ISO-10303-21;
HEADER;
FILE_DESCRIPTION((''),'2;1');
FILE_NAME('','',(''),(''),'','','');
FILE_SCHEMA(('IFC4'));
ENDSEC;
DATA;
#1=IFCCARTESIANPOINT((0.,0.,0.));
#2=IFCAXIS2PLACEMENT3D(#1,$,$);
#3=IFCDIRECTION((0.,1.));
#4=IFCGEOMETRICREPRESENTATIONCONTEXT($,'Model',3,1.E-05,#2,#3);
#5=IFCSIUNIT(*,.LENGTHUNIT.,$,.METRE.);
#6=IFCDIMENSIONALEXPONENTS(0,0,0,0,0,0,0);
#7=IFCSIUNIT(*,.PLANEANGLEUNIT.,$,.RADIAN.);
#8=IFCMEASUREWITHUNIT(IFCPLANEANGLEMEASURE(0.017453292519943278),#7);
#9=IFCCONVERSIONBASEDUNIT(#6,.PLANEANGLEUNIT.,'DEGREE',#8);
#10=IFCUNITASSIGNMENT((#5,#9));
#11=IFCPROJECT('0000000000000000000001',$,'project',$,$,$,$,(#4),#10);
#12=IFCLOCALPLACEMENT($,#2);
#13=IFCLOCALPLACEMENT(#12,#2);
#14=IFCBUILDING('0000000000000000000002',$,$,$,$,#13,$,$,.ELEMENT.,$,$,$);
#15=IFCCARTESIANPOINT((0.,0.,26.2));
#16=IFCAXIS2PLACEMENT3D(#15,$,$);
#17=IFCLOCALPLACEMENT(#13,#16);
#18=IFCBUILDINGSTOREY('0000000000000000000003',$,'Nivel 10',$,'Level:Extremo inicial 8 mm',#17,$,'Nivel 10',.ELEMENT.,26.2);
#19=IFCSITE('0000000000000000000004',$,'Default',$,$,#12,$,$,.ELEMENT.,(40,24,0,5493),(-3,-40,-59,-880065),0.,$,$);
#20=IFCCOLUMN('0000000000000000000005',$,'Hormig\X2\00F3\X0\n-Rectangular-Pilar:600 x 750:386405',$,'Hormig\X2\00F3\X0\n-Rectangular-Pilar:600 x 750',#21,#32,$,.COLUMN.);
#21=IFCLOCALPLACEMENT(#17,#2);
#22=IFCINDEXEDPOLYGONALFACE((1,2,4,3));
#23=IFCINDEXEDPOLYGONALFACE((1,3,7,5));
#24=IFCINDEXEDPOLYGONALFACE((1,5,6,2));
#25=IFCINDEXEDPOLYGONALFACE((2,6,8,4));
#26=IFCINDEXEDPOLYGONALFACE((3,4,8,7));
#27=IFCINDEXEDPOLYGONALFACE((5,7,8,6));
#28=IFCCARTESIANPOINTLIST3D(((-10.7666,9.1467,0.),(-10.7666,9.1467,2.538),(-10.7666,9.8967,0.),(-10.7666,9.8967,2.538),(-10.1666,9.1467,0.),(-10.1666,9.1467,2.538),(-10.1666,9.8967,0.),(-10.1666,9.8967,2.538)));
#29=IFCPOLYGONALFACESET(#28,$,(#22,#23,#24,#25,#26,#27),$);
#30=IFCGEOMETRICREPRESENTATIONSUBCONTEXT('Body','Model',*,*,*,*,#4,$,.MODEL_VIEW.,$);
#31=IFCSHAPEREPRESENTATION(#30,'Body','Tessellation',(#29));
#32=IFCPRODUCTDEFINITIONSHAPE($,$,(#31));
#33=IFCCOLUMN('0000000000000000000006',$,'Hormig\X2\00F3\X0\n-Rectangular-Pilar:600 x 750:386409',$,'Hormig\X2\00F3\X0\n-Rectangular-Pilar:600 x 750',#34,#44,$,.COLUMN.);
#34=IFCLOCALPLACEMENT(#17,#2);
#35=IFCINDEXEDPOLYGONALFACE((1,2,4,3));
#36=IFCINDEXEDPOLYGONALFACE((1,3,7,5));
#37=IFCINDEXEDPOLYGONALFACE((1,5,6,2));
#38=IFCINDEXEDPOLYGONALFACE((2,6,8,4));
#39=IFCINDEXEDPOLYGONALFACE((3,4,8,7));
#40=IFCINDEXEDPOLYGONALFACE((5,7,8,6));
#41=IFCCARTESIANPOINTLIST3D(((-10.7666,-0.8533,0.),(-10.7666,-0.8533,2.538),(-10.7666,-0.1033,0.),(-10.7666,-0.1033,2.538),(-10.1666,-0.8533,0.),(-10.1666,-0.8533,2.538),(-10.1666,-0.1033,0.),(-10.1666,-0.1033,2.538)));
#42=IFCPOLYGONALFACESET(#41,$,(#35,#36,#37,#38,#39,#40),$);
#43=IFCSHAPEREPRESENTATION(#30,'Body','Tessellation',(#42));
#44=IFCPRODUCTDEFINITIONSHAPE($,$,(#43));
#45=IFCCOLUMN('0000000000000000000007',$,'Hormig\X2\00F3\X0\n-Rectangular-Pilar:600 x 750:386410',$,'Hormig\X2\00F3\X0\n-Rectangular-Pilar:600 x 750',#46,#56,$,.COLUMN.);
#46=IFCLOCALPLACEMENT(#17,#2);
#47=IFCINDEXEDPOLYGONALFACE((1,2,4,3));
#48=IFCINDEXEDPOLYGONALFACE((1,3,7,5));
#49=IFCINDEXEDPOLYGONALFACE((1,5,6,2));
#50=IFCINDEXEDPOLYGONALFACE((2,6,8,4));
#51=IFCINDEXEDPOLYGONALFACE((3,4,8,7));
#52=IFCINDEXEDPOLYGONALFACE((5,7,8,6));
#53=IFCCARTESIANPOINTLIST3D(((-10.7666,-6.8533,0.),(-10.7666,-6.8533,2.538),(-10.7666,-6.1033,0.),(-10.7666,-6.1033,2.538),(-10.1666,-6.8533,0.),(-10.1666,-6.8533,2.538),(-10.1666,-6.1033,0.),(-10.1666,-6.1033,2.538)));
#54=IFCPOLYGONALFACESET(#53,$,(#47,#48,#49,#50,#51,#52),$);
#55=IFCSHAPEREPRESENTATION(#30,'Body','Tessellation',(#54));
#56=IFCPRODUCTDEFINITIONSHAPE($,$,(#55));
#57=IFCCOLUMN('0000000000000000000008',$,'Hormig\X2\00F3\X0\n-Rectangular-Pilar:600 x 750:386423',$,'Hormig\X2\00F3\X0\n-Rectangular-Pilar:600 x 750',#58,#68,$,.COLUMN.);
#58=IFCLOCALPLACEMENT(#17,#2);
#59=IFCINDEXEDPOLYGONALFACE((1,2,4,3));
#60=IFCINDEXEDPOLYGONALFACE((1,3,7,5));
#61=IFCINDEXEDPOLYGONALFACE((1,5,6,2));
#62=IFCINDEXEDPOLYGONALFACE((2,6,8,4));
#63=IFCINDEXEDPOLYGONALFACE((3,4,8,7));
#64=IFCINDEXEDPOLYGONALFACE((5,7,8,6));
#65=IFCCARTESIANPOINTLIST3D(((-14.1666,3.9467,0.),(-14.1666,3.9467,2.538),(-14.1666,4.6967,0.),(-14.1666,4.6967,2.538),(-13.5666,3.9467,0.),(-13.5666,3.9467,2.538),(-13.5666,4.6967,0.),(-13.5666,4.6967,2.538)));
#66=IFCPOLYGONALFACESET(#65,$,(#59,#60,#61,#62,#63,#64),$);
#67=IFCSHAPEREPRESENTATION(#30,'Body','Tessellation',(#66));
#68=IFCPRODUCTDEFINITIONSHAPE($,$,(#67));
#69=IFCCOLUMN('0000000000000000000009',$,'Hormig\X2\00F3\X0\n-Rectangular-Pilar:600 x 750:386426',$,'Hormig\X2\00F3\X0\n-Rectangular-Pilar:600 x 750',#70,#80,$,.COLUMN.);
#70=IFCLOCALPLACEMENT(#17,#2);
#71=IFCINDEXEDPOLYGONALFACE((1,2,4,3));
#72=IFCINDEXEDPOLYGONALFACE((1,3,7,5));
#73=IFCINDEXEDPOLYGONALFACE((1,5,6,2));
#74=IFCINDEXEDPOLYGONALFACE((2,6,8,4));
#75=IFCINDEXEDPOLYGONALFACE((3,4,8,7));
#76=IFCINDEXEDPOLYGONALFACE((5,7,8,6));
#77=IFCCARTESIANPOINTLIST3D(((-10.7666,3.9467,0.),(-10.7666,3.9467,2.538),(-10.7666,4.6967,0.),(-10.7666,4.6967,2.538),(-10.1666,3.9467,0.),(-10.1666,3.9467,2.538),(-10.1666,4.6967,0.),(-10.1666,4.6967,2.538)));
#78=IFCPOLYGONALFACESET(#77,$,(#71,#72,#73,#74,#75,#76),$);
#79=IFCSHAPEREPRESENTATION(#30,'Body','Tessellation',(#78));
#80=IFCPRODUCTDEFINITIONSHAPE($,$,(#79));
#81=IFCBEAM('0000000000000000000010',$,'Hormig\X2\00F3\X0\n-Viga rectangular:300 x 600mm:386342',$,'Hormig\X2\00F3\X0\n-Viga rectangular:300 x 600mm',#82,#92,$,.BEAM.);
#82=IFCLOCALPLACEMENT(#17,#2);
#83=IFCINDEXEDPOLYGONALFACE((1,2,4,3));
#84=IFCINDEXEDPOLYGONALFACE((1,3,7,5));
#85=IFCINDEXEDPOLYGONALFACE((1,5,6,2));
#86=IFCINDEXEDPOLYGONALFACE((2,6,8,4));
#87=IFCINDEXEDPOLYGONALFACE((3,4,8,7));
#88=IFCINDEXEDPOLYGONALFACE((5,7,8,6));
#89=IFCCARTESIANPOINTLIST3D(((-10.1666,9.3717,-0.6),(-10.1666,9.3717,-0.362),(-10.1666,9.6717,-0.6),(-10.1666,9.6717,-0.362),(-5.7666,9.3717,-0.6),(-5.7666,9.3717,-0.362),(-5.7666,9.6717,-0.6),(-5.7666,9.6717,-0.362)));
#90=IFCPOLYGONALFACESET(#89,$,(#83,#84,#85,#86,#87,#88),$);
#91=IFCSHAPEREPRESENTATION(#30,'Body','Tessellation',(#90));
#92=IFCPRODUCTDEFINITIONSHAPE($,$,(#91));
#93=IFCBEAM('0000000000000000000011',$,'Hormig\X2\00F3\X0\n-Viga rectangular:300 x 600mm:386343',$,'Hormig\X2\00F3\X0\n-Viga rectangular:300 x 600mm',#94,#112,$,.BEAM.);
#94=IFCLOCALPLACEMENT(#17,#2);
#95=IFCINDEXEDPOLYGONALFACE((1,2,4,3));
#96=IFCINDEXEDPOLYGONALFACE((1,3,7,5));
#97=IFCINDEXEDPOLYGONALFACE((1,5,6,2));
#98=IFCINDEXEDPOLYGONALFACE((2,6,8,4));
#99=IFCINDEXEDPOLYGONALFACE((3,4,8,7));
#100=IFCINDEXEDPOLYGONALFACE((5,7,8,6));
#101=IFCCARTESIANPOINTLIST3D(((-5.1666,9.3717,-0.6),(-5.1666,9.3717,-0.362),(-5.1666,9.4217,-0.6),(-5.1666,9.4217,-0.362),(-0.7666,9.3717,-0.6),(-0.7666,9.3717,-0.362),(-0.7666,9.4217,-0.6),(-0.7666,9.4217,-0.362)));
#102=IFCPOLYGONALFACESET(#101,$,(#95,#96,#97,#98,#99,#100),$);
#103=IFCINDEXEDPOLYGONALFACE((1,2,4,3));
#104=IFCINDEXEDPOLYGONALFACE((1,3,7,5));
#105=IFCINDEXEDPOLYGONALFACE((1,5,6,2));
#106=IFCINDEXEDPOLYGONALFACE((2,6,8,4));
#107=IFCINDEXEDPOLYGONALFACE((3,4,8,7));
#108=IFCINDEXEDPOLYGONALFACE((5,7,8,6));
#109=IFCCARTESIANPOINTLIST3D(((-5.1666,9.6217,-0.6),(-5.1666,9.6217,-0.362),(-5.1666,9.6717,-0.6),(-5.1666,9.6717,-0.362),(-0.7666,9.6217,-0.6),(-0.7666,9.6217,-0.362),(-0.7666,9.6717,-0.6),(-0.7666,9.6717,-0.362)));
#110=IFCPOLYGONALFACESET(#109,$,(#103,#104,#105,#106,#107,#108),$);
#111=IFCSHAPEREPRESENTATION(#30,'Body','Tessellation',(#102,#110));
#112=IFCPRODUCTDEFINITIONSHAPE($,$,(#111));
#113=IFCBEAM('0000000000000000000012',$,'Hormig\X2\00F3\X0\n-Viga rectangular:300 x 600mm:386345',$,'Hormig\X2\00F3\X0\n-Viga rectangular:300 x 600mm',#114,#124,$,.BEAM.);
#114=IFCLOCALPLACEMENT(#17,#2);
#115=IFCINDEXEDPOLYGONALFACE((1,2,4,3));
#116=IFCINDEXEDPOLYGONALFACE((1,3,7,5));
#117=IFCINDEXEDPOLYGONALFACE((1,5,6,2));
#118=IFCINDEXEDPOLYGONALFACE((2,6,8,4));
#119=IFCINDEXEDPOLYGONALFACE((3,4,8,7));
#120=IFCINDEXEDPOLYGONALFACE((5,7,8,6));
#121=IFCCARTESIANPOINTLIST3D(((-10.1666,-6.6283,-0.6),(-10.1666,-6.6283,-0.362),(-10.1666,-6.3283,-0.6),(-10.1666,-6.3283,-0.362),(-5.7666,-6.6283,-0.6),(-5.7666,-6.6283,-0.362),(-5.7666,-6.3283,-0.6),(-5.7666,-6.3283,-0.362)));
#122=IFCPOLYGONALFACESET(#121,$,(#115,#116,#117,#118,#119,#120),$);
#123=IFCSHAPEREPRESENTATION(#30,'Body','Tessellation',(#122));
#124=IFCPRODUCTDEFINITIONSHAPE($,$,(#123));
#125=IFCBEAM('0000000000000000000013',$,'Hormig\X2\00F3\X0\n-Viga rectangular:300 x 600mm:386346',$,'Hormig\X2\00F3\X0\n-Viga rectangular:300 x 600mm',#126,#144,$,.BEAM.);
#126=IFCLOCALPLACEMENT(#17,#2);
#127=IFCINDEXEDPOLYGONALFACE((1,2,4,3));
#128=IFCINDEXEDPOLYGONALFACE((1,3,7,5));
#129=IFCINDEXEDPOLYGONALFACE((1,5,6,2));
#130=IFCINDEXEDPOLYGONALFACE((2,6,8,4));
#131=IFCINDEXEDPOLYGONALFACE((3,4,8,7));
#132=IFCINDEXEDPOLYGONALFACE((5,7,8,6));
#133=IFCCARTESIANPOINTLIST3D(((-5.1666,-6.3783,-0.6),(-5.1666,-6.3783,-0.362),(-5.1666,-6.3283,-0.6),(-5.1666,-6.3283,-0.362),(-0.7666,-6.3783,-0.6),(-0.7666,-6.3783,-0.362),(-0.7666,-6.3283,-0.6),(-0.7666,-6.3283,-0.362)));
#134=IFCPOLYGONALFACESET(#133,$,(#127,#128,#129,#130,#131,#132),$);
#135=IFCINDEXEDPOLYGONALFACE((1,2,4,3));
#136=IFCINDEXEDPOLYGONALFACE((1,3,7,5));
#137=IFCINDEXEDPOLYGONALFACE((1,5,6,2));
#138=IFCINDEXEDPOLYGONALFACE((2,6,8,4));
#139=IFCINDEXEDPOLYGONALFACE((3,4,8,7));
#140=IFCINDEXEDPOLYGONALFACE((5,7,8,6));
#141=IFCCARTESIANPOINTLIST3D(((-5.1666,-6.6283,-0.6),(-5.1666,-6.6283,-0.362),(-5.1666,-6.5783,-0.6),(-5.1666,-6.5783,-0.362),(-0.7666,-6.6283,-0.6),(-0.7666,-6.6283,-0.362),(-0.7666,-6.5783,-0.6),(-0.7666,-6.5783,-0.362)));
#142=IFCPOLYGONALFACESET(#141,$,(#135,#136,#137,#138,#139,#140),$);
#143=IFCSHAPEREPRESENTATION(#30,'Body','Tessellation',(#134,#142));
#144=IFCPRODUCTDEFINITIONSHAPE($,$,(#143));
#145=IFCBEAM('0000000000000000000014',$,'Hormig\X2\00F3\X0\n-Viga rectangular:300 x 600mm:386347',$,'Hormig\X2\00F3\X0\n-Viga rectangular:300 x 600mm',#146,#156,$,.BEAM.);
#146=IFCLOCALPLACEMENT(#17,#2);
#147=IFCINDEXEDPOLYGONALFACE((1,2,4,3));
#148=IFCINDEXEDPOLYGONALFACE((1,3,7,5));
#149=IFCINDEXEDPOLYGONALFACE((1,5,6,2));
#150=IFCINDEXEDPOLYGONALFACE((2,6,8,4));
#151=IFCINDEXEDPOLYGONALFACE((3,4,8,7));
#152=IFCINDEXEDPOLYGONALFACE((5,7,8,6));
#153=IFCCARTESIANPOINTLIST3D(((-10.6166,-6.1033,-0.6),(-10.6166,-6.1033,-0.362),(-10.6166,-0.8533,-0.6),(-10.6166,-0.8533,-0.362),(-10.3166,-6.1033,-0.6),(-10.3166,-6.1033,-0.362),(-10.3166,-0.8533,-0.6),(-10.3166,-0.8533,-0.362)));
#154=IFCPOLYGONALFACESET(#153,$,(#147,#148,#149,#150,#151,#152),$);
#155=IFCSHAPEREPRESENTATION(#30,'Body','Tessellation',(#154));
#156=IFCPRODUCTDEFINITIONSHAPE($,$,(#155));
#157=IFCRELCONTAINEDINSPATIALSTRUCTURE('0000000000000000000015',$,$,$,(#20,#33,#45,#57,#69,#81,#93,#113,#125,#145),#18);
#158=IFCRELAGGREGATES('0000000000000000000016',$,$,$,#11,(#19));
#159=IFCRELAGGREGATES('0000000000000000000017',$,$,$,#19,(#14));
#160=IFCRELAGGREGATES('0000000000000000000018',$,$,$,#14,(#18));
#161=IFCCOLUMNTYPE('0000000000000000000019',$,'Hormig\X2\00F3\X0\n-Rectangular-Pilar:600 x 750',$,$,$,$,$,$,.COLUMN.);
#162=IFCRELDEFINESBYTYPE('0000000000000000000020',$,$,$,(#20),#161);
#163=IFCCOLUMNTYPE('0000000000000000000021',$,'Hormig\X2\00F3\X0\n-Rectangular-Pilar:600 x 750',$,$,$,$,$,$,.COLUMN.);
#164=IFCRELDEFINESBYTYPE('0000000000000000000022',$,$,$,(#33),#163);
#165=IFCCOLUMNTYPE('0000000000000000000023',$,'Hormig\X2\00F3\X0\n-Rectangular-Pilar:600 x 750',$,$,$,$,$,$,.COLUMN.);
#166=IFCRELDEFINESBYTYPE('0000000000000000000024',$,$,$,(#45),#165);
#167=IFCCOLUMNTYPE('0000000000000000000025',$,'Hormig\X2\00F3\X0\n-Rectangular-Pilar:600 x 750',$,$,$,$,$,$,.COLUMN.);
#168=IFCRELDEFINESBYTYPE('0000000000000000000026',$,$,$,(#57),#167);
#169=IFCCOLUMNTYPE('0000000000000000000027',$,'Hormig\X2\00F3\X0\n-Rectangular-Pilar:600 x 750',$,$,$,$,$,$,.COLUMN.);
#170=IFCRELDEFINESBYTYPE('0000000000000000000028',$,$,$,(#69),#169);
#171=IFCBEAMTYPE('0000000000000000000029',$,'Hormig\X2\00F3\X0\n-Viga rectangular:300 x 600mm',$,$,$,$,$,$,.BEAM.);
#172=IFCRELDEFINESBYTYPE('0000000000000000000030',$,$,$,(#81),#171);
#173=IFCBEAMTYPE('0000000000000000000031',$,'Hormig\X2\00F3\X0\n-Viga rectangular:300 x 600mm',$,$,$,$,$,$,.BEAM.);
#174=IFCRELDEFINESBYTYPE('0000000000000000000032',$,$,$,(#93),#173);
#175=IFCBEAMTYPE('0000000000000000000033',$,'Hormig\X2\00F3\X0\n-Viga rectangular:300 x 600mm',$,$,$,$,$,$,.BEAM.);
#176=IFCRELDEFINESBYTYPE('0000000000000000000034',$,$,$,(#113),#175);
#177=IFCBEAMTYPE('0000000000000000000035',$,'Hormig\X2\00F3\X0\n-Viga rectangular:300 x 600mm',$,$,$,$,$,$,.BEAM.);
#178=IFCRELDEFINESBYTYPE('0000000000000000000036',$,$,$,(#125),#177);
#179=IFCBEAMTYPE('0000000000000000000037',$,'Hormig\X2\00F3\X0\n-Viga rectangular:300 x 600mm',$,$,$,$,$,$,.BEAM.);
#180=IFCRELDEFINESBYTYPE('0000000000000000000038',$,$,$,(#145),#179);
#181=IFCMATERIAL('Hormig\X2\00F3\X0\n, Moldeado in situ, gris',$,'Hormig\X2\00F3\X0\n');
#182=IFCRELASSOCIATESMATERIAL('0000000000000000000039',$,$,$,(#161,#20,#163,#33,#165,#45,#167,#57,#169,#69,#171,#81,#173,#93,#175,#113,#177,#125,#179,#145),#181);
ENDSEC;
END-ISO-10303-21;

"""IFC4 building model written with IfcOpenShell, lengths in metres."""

from ifc_helpers import new_model, entity, si_unit, converted_unit, direction, frame, origin, place, context, subcontext, project, spatial, indexed_curve, outline, extrude, source, transform, mapped, material, type_object, type_shapes, element, save


model = new_model("IFC4")

# Units and contexts
model_context = context("Model", 3, precision=1e-05, world=origin(), true_north=direction((0.0, 1.0)))
body_context = subcontext(model_context, "Body", "Model", "MODEL_VIEW")
ifc_project = project(units=[si_unit("LENGTHUNIT", "METRE"), converted_unit("PLANEANGLEUNIT", "DEGREE", entity("IfcPlaneAngleMeasure", 0.017453292519943278), si_unit("PLANEANGLEUNIT", "RADIAN"), dimensions=[0, 0, 0, 0, 0, 0, 0])], contexts=[model_context])

# Site, building, storey
site_placement = place(None, origin())
site = spatial("IfcSite", under=ifc_project, at=site_placement, Name="Default", CompositionType="ELEMENT", RefLatitude=(40, 24, 0, 5493), RefLongitude=(-3, -40, -59, -880065), RefElevation=0.0)
building_placement = place(site_placement, origin())
building = spatial("IfcBuilding", under=site, at=building_placement, CompositionType="ELEMENT")
storey_placement = place(building_placement, frame((0.0, 0.0, 26.2)))
storey = spatial("IfcBuildingStorey", under=building, at=storey_placement, Name="Nivel 10", ObjectType="Level:Extremo inicial 8 mm", LongName="Nivel 10", CompositionType="ELEMENT", Elevation=26.2)

# Columns
ifc_material_1 = material(Name="Hormigón, Moldeado in situ, gris", Category="Hormigón")
column_type_1 = type_object("IfcColumnType", Name="Hormigón-Rectangular-Pilar:600 x 750", PredefinedType="COLUMN", material=ifc_material_1)
shared_shape_1 = source(origin(), body_context, "Body", "SweptSolid", [
    extrude(outline(indexed_curve([(-0.3, -0.375), (0.3, -0.375), (0.3, 0.375), (-0.3, 0.375), (-0.3, -0.375)], self_intersect=False)), frame((-10.4666, 9.5217, 26.2), z_axis=(0.0, 0.0, 1.0), x_axis=(-1.0, 0.0, 0.0)), (0.0, 0.0, 1.0), 2.538),
])
type_shapes(column_type_1, [shared_shape_1])
column_1_placement = place(storey_placement, frame((0.0, 0.0, -26.2)))
element("IfcColumn", 1, at=column_1_placement, inside=storey, type_object=column_type_1, material=ifc_material_1, Name="Hormigón-Rectangular-Pilar:600 x 750:386405", ObjectType="Hormigón-Rectangular-Pilar:600 x 750", PredefinedType="COLUMN", context=body_context, shape_type="MappedRepresentation", body=[
    mapped(shared_shape_1, transform((0.0, 0.0, 0.0), scale=1.0)),
])
column_type_2 = type_object("IfcColumnType", Name="Hormigón-Rectangular-Pilar:600 x 750", PredefinedType="COLUMN", material=ifc_material_1)
shared_shape_2 = source(origin(), body_context, "Body", "SweptSolid", [
    extrude(outline(indexed_curve([(-0.3, -0.375), (0.3, -0.375), (0.3, 0.375), (-0.3, 0.375), (-0.3, -0.375)], self_intersect=False)), frame((-10.4666, -0.4783, 26.2), z_axis=(0.0, 0.0, 1.0), x_axis=(-1.0, 0.0, 0.0)), (0.0, 0.0, 1.0), 2.538),
])
type_shapes(column_type_2, [shared_shape_2])
column_2_placement = place(storey_placement, frame((0.0, 0.0, -26.2)))
element("IfcColumn", 2, at=column_2_placement, inside=storey, type_object=column_type_2, material=ifc_material_1, Name="Hormigón-Rectangular-Pilar:600 x 750:386409", ObjectType="Hormigón-Rectangular-Pilar:600 x 750", PredefinedType="COLUMN", context=body_context, shape_type="MappedRepresentation", body=[
    mapped(shared_shape_2, transform((0.0, 0.0, 0.0), scale=1.0)),
])
column_type_3 = type_object("IfcColumnType", Name="Hormigón-Rectangular-Pilar:600 x 750", PredefinedType="COLUMN", material=ifc_material_1)
shared_shape_3 = source(origin(), body_context, "Body", "SweptSolid", [
    extrude(outline(indexed_curve([(-0.3, -0.375), (0.3, -0.375), (0.3, 0.375), (-0.3, 0.375), (-0.3, -0.375)], self_intersect=False)), frame((-10.4666, -6.4783, 26.2), z_axis=(0.0, 0.0, 1.0), x_axis=(-1.0, 0.0, 0.0)), (0.0, 0.0, 1.0), 2.538),
])
type_shapes(column_type_3, [shared_shape_3])
column_3_placement = place(storey_placement, frame((0.0, 0.0, -26.2)))
element("IfcColumn", 3, at=column_3_placement, inside=storey, type_object=column_type_3, material=ifc_material_1, Name="Hormigón-Rectangular-Pilar:600 x 750:386410", ObjectType="Hormigón-Rectangular-Pilar:600 x 750", PredefinedType="COLUMN", context=body_context, shape_type="MappedRepresentation", body=[
    mapped(shared_shape_3, transform((0.0, 0.0, 0.0), scale=1.0)),
])
column_type_4 = type_object("IfcColumnType", Name="Hormigón-Rectangular-Pilar:600 x 750", PredefinedType="COLUMN", material=ifc_material_1)
shared_shape_4 = source(origin(), body_context, "Body", "SweptSolid", [
    extrude(outline(indexed_curve([(-0.3, -0.375), (0.3, -0.375), (0.3, 0.375), (-0.3, 0.375), (-0.3, -0.375)], self_intersect=False)), frame((-13.8666, 4.3217, 26.2), z_axis=(0.0, 0.0, 1.0), x_axis=(-1.0, 0.0, 0.0)), (0.0, 0.0, 1.0), 2.538),
])
type_shapes(column_type_4, [shared_shape_4])
column_4_placement = place(storey_placement, frame((0.0, 0.0, -26.2)))
element("IfcColumn", 4, at=column_4_placement, inside=storey, type_object=column_type_4, material=ifc_material_1, Name="Hormigón-Rectangular-Pilar:600 x 750:386423", ObjectType="Hormigón-Rectangular-Pilar:600 x 750", PredefinedType="COLUMN", context=body_context, shape_type="MappedRepresentation", body=[
    mapped(shared_shape_4, transform((0.0, 0.0, 0.0), scale=1.0)),
])
column_type_5 = type_object("IfcColumnType", Name="Hormigón-Rectangular-Pilar:600 x 750", PredefinedType="COLUMN", material=ifc_material_1)
shared_shape_5 = source(origin(), body_context, "Body", "SweptSolid", [
    extrude(outline(indexed_curve([(-0.3, -0.375), (0.3, -0.375), (0.3, 0.375), (-0.3, 0.375), (-0.3, -0.375)], self_intersect=False)), frame((-10.4666, 4.3217, 26.2), z_axis=(0.0, 0.0, 1.0), x_axis=(-1.0, 0.0, 0.0)), (0.0, 0.0, 1.0), 2.538),
])
type_shapes(column_type_5, [shared_shape_5])
column_5_placement = place(storey_placement, frame((0.0, 0.0, -26.2)))
element("IfcColumn", 5, at=column_5_placement, inside=storey, type_object=column_type_5, material=ifc_material_1, Name="Hormigón-Rectangular-Pilar:600 x 750:386426", ObjectType="Hormigón-Rectangular-Pilar:600 x 750", PredefinedType="COLUMN", context=body_context, shape_type="MappedRepresentation", body=[
    mapped(shared_shape_5, transform((0.0, 0.0, 0.0), scale=1.0)),
])

# Beams
beam_type_1 = type_object("IfcBeamType", Name="Hormigón-Viga rectangular:300 x 600mm", PredefinedType="BEAM", material=ifc_material_1)
shared_shape_6 = source(origin(), body_context, "Body", "SweptSolid", [
    extrude(outline(indexed_curve([(-0.119, -0.15), (0.119, -0.15), (0.119, 0.15), (-0.119, 0.15), (-0.119, -0.15)], self_intersect=False)), frame((-5.7666, 9.5217, 25.719), z_axis=(-1.0, 0.0, 0.0), x_axis=(0.0, 0.0, -1.0)), (0.0, 0.0, 1.0), 4.4),
])
type_shapes(beam_type_1, [shared_shape_6])
beam_1_placement = place(storey_placement, frame((0.0, 0.0, -26.2)))
element("IfcBeam", 6, at=beam_1_placement, inside=storey, type_object=beam_type_1, material=ifc_material_1, Name="Hormigón-Viga rectangular:300 x 600mm:386342", ObjectType="Hormigón-Viga rectangular:300 x 600mm", PredefinedType="BEAM", context=body_context, shape_type="MappedRepresentation", body=[
    mapped(shared_shape_6, transform((0.0, 0.0, 0.0), scale=1.0)),
])
beam_type_2 = type_object("IfcBeamType", Name="Hormigón-Viga rectangular:300 x 600mm", PredefinedType="BEAM", material=ifc_material_1)
shared_shape_7 = source(origin(), body_context, "Body", "SweptSolid", [
    extrude(outline(indexed_curve([(-0.119, -0.025), (0.119, -0.025), (0.119, 0.025), (-0.119, 0.025), (-0.119, -0.025)], self_intersect=False)), frame((-5.1666, 9.3967, 25.719), z_axis=(1.0, 0.0, 0.0), x_axis=(0.0, 0.0, -1.0)), (0.0, 0.0, 1.0), 4.4),
    extrude(outline(indexed_curve([(-0.119, -0.025), (0.119, -0.025), (0.119, 0.025), (-0.119, 0.025), (-0.119, -0.025)], self_intersect=False)), frame((-5.1666, 9.6467, 25.719), z_axis=(1.0, 0.0, 0.0), x_axis=(0.0, 0.0, -1.0)), (0.0, 0.0, 1.0), 4.4),
])
type_shapes(beam_type_2, [shared_shape_7])
beam_2_placement = place(storey_placement, frame((0.0, 0.0, -26.2)))
element("IfcBeam", 7, at=beam_2_placement, inside=storey, type_object=beam_type_2, material=ifc_material_1, Name="Hormigón-Viga rectangular:300 x 600mm:386343", ObjectType="Hormigón-Viga rectangular:300 x 600mm", PredefinedType="BEAM", context=body_context, shape_type="MappedRepresentation", body=[
    mapped(shared_shape_7, transform((0.0, 0.0, 0.0), scale=1.0)),
])
beam_type_3 = type_object("IfcBeamType", Name="Hormigón-Viga rectangular:300 x 600mm", PredefinedType="BEAM", material=ifc_material_1)
shared_shape_8 = source(origin(), body_context, "Body", "SweptSolid", [
    extrude(outline(indexed_curve([(-0.119, -0.15), (0.119, -0.15), (0.119, 0.15), (-0.119, 0.15), (-0.119, -0.15)], self_intersect=False)), frame((-10.1666, -6.4783, 25.719), z_axis=(1.0, 0.0, 0.0), x_axis=(0.0, 0.0, -1.0)), (0.0, 0.0, 1.0), 4.4),
])
type_shapes(beam_type_3, [shared_shape_8])
beam_3_placement = place(storey_placement, frame((0.0, 0.0, -26.2)))
element("IfcBeam", 8, at=beam_3_placement, inside=storey, type_object=beam_type_3, material=ifc_material_1, Name="Hormigón-Viga rectangular:300 x 600mm:386345", ObjectType="Hormigón-Viga rectangular:300 x 600mm", PredefinedType="BEAM", context=body_context, shape_type="MappedRepresentation", body=[
    mapped(shared_shape_8, transform((0.0, 0.0, 0.0), scale=1.0)),
])
beam_type_4 = type_object("IfcBeamType", Name="Hormigón-Viga rectangular:300 x 600mm", PredefinedType="BEAM", material=ifc_material_1)
shared_shape_9 = source(origin(), body_context, "Body", "SweptSolid", [
    extrude(outline(indexed_curve([(-0.119, -0.025), (0.119, -0.025), (0.119, 0.025), (-0.119, 0.025), (-0.119, -0.025)], self_intersect=False)), frame((-0.7666, -6.3533, 25.719), z_axis=(-1.0, 0.0, 0.0), x_axis=(0.0, 0.0, -1.0)), (0.0, 0.0, 1.0), 4.4),
    extrude(outline(indexed_curve([(-0.119, -0.025), (0.119, -0.025), (0.119, 0.025), (-0.119, 0.025), (-0.119, -0.025)], self_intersect=False)), frame((-0.7666, -6.6033, 25.719), z_axis=(-1.0, 0.0, 0.0), x_axis=(0.0, 0.0, -1.0)), (0.0, 0.0, 1.0), 4.4),
])
type_shapes(beam_type_4, [shared_shape_9])
beam_4_placement = place(storey_placement, frame((0.0, 0.0, -26.2)))
element("IfcBeam", 9, at=beam_4_placement, inside=storey, type_object=beam_type_4, material=ifc_material_1, Name="Hormigón-Viga rectangular:300 x 600mm:386346", ObjectType="Hormigón-Viga rectangular:300 x 600mm", PredefinedType="BEAM", context=body_context, shape_type="MappedRepresentation", body=[
    mapped(shared_shape_9, transform((0.0, 0.0, 0.0), scale=1.0)),
])
beam_type_5 = type_object("IfcBeamType", Name="Hormigón-Viga rectangular:300 x 600mm", PredefinedType="BEAM", material=ifc_material_1)
shared_shape_10 = source(origin(), body_context, "Body", "SweptSolid", [
    extrude(outline(indexed_curve([(-0.15, -0.119), (0.15, -0.119), (0.15, 0.119), (-0.15, 0.119), (-0.15, -0.119)], self_intersect=False)), frame((-10.4666, -6.1033, 25.719), z_axis=(0.0, 1.0, 0.0), x_axis=(-1.0, 0.0, 0.0)), (0.0, 0.0, 1.0), 5.25),
])
type_shapes(beam_type_5, [shared_shape_10])
beam_5_placement = place(storey_placement, frame((0.0, 0.0, -26.2)))
element("IfcBeam", 10, at=beam_5_placement, inside=storey, type_object=beam_type_5, material=ifc_material_1, Name="Hormigón-Viga rectangular:300 x 600mm:386347", ObjectType="Hormigón-Viga rectangular:300 x 600mm", PredefinedType="BEAM", context=body_context, shape_type="MappedRepresentation", body=[
    mapped(shared_shape_10, transform((0.0, 0.0, 0.0), scale=1.0)),
])

save(model, "model.ifc")
